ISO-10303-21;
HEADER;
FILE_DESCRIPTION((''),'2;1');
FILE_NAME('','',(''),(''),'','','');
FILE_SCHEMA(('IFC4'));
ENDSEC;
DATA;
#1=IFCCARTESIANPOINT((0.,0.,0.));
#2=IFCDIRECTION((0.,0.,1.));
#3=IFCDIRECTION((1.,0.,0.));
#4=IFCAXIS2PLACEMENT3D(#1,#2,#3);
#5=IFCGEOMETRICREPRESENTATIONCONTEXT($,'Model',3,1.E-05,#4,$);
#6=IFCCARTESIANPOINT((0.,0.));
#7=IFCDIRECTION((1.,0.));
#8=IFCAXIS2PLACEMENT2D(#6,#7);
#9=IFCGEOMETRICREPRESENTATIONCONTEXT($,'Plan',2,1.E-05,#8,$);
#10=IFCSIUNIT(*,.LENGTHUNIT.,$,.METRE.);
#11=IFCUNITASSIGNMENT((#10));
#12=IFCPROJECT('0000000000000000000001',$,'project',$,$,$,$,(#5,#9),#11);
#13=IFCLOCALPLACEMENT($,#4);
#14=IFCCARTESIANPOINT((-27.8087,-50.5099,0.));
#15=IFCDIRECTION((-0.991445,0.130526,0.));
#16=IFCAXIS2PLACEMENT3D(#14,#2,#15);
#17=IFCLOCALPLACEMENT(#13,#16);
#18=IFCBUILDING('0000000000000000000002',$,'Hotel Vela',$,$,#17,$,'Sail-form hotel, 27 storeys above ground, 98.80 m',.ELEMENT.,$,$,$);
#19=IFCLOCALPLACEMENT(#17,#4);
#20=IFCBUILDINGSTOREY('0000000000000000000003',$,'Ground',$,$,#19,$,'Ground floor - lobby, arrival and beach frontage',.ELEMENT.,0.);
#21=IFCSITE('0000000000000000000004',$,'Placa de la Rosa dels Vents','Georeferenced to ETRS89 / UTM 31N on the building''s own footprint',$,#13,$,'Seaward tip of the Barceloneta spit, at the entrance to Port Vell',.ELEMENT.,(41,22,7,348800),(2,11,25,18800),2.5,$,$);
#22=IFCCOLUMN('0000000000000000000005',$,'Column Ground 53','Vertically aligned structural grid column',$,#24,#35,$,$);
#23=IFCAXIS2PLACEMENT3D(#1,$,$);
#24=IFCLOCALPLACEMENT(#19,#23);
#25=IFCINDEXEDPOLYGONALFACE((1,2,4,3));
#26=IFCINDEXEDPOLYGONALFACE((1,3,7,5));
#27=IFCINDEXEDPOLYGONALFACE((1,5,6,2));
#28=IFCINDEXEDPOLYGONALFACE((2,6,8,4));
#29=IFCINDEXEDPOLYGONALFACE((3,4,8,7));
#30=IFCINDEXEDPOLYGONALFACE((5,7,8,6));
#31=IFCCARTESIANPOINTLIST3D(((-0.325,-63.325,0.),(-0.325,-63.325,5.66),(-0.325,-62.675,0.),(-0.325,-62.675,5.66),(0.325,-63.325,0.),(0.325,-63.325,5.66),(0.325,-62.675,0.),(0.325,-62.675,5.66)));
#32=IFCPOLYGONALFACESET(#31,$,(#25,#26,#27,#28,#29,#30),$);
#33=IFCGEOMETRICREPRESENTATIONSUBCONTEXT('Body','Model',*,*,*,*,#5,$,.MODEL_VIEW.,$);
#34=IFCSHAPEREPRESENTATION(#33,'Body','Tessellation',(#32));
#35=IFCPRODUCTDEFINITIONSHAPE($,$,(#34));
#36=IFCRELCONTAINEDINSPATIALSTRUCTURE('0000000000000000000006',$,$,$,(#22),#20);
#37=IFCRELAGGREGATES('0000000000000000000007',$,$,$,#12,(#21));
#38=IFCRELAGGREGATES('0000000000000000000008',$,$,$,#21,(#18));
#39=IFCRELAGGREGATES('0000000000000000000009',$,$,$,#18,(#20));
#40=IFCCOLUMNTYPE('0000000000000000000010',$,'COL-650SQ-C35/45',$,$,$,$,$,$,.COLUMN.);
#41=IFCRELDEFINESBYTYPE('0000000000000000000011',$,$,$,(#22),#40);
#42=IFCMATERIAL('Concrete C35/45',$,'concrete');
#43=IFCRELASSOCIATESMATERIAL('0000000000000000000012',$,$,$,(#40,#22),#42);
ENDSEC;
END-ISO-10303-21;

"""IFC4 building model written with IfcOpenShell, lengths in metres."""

from ifc_helpers import new_model, si_unit, frame, origin_with_axes, origin_2d_with_axis, place, context, subcontext, project, spatial, line, indexed_curve, rectangle, outline, extrude, material, material_profile, profile_set, profile_usage, type_object, element, save


model = new_model("IFC4")

# Units and contexts
model_context = context("Model", 3, precision=1e-05, world=origin_with_axes())
plan_context = context("Plan", 2, precision=1e-05, world=origin_2d_with_axis())
body_context = subcontext(model_context, "Body", "Model", "MODEL_VIEW")
ifc_project = project(units=[si_unit("LENGTHUNIT", "METRE")], contexts=[model_context, plan_context])

# Site, building, storey
site_placement = place(None, origin_with_axes())
site = spatial("IfcSite", under=ifc_project, at=site_placement, Name="Placa de la Rosa dels Vents", Description="Georeferenced to ETRS89 / UTM 31N on the building's own footprint", LongName="Seaward tip of the Barceloneta spit, at the entrance to Port Vell", CompositionType="ELEMENT", RefLatitude=(41, 22, 7, 348800), RefLongitude=(2, 11, 25, 18800), RefElevation=2.5)
building_placement = place(site_placement, frame((-27.8087, -50.5099, 0.0), z_axis=(0.0, 0.0, 1.0), x_axis=(-0.991445, 0.130526, 0.0)))
building = spatial("IfcBuilding", under=site, at=building_placement, Name="Hotel Vela", LongName="Sail-form hotel, 27 storeys above ground, 98.80 m", CompositionType="ELEMENT")
storey_placement = place(building_placement, origin_with_axes())
storey = spatial("IfcBuildingStorey", under=building, at=storey_placement, Name="Ground", LongName="Ground floor - lobby, arrival and beach frontage", CompositionType="ELEMENT", Elevation=0.0)

# Column
ifc_material = material(Name="Concrete C35/45", Category="concrete")
ifc_material_profile = material_profile(ifc_material, rectangle(XDim=0.65, YDim=0.65))
ifc_profile_set = profile_set([ifc_material_profile], Name="COL-650SQ-C35/45")
column_type = type_object("IfcColumnType", Name="COL-650SQ-C35/45", PredefinedType="COLUMN", material=ifc_profile_set)
ifc_profile_usage_1 = profile_usage(ifc_profile_set)
column_1_placement = place(storey_placement, frame((-0.325, -63.325, 0.0), z_axis=(0.0, 0.0, 1.0), x_axis=(1.0, 0.0, 0.0)))
element("IfcColumn", 1, at=column_1_placement, inside=storey, type_object=column_type, material=ifc_profile_usage_1, Name="Column Ground 53", Description="Vertically aligned structural grid column", context=body_context, shape_type="SweptSolid", body=[
    extrude(outline(indexed_curve([(0.0, 0.0), (0.65, 0.0), (0.65, 0.65), (0.0, 0.65)], segments=[line(1, 2, 3, 4, 1)])), origin_with_axes(), (0.0, 0.0, 1.0), 5.66),
])

save(model, "model.ifc")
